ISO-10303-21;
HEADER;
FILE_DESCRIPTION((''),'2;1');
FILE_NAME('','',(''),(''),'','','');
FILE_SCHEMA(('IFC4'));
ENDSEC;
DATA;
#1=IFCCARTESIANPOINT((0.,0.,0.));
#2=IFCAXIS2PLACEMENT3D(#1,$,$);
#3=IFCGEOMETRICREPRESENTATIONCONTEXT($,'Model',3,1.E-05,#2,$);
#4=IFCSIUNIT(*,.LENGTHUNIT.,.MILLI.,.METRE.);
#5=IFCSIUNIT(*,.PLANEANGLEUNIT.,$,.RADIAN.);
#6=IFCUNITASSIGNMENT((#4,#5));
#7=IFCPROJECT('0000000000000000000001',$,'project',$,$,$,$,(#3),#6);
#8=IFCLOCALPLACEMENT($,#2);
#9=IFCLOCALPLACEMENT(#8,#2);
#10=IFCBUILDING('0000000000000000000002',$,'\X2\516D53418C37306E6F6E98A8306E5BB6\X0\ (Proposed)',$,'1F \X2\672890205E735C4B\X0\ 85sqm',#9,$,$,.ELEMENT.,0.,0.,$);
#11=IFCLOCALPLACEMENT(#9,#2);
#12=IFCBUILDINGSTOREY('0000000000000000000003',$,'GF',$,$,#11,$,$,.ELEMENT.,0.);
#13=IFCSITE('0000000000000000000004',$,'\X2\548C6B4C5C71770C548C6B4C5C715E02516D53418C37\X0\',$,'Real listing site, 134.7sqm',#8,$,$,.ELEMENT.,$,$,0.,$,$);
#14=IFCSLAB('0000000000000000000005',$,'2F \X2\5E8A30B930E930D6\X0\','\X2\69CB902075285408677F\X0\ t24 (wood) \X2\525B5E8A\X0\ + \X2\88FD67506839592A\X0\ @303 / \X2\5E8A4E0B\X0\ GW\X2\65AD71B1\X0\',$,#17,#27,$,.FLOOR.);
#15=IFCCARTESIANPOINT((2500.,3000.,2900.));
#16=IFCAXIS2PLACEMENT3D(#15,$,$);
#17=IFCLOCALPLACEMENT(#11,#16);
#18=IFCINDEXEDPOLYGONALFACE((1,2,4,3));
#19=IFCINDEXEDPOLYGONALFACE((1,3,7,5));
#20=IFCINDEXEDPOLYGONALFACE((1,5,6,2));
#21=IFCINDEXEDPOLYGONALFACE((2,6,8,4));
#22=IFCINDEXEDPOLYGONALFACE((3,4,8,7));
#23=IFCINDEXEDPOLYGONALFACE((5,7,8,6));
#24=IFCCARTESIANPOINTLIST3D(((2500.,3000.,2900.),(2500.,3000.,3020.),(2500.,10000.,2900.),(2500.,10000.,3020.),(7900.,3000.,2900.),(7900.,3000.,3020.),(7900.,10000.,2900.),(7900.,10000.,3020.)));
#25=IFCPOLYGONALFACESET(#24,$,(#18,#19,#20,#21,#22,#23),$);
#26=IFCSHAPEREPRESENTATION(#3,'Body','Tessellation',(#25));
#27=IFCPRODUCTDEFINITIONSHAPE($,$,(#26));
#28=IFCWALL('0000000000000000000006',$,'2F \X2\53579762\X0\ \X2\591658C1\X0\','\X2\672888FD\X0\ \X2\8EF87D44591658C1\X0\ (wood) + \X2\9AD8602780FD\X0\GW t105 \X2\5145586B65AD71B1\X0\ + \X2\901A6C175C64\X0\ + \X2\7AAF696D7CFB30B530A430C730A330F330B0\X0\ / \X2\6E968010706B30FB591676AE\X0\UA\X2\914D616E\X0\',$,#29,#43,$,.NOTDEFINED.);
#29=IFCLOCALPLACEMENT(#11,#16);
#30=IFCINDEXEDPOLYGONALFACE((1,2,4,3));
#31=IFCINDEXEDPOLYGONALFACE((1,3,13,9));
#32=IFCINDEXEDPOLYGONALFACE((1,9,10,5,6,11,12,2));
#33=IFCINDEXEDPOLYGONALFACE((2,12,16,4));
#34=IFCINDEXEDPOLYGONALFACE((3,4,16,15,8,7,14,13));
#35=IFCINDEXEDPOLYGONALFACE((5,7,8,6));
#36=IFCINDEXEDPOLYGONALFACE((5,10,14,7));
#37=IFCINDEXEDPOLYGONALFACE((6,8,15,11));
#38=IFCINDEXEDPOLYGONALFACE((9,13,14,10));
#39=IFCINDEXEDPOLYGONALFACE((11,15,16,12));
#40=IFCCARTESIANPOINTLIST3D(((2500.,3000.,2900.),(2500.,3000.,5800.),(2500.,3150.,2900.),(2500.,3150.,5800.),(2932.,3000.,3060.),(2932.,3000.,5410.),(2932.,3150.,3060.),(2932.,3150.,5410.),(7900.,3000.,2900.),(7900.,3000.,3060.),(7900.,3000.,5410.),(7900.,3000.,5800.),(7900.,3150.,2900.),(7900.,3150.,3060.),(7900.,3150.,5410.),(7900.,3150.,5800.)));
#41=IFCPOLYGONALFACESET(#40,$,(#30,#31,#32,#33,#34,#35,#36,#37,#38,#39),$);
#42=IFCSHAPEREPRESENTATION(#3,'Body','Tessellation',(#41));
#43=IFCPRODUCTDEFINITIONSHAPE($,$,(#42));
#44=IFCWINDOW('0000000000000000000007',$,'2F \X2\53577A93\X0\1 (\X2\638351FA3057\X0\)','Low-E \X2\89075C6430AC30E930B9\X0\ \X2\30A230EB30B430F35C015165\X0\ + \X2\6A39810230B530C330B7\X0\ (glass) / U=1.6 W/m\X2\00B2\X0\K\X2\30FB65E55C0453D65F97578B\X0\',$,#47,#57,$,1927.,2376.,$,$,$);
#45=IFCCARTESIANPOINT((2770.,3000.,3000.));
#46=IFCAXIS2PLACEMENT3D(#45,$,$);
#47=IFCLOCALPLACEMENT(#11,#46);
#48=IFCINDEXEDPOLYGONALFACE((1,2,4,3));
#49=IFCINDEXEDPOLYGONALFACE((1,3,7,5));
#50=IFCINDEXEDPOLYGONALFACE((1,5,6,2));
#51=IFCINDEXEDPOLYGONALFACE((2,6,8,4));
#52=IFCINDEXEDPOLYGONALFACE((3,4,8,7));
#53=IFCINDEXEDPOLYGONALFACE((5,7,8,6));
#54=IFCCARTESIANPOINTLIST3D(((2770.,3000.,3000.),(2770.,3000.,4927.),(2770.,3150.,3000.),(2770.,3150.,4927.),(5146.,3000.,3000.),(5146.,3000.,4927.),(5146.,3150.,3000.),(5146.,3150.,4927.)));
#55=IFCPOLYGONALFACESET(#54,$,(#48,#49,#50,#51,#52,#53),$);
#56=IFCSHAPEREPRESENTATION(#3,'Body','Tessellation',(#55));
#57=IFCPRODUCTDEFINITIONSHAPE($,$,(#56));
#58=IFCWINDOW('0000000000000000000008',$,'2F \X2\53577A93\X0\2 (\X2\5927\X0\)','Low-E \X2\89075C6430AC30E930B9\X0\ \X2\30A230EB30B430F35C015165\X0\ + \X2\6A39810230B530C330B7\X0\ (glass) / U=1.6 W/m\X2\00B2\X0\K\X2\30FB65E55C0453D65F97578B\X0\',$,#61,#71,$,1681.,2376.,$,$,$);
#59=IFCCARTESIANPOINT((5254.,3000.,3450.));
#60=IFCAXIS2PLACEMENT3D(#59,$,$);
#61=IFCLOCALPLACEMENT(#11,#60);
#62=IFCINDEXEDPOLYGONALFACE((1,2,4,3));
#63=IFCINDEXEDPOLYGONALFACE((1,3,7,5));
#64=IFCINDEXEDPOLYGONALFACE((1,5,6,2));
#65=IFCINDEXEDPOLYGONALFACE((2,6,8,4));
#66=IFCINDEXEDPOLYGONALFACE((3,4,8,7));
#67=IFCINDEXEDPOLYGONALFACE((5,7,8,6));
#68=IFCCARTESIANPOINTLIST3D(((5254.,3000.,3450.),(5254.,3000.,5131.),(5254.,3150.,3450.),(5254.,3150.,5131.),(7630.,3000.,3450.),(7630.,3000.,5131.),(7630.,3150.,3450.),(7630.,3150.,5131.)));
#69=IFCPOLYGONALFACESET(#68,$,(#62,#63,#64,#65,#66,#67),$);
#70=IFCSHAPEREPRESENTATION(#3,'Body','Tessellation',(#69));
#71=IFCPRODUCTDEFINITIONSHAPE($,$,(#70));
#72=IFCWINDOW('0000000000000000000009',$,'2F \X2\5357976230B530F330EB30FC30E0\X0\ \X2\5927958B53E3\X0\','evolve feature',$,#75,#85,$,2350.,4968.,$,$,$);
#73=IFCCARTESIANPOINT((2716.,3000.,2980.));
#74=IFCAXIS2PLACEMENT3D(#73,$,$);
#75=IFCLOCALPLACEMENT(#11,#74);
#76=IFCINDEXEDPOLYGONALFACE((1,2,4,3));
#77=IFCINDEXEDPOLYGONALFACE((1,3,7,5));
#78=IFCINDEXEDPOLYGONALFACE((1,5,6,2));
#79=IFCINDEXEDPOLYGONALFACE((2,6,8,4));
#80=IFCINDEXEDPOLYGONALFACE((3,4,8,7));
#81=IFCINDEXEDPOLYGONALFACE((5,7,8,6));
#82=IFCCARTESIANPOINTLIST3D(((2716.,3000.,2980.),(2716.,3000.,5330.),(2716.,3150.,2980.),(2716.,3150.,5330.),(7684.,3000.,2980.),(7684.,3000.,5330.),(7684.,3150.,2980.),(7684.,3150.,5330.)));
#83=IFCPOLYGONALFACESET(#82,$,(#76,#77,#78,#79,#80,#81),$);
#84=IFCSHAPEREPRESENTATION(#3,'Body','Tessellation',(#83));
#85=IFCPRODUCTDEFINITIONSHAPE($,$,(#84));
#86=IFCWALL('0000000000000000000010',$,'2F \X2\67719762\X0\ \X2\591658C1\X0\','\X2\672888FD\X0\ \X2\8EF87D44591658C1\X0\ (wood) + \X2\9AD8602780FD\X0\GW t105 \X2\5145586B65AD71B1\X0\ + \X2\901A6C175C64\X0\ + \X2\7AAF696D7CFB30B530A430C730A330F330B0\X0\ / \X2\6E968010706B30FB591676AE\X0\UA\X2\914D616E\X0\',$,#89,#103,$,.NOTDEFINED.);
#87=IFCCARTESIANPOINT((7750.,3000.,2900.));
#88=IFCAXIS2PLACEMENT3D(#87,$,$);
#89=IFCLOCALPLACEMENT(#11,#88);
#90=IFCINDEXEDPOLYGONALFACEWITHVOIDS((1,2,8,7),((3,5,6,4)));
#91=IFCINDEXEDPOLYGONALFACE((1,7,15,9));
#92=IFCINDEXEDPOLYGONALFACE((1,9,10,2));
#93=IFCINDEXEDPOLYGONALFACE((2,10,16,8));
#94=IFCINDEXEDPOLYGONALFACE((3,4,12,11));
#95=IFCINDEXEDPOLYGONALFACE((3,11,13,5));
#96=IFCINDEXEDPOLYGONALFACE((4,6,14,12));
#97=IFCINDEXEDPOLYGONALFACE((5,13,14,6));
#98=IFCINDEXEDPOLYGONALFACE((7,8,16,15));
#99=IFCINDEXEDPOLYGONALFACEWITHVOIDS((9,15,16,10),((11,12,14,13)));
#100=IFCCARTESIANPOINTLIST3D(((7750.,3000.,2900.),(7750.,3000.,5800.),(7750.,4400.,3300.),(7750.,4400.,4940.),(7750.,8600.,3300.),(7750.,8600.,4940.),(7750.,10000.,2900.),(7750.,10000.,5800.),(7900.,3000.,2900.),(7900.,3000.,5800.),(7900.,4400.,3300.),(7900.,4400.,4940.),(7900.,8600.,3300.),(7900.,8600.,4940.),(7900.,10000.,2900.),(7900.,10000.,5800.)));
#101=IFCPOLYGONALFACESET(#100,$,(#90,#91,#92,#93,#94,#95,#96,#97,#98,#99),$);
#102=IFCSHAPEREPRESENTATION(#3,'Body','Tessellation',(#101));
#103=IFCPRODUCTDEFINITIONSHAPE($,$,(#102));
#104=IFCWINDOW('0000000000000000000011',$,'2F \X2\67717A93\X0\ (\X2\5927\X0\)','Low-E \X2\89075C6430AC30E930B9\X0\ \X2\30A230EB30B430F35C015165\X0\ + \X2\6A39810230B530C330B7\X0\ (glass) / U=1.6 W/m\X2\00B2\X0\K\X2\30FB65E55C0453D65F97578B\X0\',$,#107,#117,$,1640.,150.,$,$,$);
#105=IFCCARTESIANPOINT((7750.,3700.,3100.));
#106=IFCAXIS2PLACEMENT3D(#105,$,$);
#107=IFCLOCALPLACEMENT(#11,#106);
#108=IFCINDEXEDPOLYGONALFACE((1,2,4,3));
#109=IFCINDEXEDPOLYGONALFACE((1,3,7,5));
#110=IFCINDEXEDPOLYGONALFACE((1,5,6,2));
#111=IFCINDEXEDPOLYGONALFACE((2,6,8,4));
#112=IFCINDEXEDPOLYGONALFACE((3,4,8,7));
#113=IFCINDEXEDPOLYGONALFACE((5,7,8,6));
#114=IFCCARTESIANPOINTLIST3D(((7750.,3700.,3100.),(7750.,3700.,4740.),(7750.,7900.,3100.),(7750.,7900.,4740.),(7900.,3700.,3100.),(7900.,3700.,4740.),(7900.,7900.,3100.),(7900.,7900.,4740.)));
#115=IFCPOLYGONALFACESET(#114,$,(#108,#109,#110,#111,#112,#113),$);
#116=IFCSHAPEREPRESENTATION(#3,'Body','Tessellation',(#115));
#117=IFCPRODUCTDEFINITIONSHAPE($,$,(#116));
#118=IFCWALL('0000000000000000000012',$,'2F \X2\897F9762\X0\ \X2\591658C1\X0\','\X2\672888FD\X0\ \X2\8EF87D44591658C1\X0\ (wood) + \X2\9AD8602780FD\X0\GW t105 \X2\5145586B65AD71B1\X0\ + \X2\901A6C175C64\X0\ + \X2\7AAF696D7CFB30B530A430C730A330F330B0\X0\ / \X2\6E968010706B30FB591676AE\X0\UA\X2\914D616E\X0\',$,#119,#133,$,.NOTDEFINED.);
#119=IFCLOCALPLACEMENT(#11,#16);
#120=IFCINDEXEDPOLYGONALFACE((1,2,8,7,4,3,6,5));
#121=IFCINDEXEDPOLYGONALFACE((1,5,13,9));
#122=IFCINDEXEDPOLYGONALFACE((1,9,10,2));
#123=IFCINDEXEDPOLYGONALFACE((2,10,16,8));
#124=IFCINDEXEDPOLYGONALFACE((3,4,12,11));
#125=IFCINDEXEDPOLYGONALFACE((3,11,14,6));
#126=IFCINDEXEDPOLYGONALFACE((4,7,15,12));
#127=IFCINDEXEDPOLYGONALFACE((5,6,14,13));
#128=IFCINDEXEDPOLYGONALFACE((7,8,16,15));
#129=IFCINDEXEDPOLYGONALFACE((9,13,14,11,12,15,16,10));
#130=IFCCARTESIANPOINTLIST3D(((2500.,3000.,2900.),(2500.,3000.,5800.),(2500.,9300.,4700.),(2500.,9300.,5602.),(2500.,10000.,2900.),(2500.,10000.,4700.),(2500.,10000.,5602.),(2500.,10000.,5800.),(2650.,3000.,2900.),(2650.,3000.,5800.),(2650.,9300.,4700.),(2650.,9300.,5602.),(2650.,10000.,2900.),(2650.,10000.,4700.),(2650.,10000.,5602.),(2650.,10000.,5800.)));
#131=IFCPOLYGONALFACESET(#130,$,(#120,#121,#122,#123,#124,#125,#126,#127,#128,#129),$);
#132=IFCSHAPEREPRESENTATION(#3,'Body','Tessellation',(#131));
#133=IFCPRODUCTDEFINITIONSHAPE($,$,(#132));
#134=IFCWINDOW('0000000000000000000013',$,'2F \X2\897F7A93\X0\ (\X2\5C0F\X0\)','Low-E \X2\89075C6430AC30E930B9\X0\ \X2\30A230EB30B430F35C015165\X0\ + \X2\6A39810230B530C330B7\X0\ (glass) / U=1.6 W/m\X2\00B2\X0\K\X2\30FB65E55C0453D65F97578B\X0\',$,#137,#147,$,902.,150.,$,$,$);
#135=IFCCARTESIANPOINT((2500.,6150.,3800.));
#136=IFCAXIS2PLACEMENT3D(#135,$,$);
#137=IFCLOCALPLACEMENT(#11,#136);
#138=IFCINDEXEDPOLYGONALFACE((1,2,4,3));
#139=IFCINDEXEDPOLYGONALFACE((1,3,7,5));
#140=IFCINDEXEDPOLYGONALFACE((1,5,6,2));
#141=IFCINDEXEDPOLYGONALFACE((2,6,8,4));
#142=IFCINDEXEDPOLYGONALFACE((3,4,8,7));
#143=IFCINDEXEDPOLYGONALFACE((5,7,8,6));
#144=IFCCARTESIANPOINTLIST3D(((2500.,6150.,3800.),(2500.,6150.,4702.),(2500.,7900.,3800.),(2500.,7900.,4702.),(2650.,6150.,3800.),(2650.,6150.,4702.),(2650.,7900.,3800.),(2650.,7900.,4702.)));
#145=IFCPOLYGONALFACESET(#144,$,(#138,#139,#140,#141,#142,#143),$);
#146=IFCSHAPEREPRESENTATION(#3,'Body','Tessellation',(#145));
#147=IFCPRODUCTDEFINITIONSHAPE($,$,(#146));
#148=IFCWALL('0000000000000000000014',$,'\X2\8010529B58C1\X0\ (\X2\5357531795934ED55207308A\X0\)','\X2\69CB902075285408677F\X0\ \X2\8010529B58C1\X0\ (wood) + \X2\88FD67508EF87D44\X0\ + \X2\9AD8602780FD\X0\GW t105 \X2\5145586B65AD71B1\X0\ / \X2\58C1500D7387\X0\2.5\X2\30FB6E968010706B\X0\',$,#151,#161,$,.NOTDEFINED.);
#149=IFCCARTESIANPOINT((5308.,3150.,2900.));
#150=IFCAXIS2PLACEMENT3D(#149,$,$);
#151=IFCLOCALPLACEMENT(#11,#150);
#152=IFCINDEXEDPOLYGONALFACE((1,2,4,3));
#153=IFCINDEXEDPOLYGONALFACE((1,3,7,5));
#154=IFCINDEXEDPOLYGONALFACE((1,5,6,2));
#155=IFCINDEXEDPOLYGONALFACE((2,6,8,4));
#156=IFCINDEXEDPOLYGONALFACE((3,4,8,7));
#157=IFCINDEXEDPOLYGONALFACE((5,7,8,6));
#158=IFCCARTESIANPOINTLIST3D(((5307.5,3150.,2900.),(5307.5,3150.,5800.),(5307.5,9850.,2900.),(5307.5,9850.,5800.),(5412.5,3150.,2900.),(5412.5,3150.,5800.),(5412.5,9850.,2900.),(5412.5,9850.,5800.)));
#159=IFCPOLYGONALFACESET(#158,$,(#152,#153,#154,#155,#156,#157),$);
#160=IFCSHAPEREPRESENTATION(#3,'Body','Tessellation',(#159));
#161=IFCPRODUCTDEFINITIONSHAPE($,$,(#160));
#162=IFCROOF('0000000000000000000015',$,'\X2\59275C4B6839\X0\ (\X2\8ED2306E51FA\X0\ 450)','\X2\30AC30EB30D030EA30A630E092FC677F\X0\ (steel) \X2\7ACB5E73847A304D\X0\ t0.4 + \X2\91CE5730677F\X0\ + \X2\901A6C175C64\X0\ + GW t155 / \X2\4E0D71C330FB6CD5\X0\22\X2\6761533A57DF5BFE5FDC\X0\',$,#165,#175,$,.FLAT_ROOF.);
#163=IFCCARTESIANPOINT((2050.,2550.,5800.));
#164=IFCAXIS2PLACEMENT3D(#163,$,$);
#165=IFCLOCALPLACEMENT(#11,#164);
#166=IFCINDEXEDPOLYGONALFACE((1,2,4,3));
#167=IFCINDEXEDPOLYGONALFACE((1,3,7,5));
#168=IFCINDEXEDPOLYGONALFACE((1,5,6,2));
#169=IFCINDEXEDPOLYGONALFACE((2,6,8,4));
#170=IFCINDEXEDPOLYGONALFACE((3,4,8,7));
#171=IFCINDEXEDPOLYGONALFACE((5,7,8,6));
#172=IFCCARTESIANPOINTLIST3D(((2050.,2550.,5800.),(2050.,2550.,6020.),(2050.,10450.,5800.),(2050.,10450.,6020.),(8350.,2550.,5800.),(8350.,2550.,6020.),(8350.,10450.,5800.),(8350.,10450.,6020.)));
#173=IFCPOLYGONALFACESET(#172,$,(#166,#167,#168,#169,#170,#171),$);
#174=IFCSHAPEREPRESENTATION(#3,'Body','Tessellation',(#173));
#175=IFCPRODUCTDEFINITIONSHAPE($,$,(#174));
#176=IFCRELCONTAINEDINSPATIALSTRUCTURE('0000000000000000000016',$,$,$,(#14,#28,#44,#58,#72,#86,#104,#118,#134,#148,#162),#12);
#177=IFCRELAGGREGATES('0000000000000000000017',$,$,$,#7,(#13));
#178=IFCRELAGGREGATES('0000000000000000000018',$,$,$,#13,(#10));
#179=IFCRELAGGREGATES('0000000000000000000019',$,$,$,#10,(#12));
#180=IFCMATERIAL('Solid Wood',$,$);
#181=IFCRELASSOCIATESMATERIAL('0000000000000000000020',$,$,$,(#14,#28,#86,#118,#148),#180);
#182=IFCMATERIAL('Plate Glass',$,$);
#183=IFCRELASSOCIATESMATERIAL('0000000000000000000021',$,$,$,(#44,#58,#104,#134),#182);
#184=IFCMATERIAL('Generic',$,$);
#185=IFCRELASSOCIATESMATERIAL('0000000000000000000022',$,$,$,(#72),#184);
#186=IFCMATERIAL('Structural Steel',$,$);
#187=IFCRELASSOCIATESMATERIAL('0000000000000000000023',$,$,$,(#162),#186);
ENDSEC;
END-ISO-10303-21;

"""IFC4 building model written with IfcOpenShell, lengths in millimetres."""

from ifc_helpers import new_model, si_unit, frame, frame_2d, origin, place, context, project, spatial, rectangle, extrude, material, element, fill, save


model = new_model("IFC4")

# Units and contexts
model_context = context("Model", 3, precision=1e-05, world=origin())
ifc_project = project(units=[si_unit("LENGTHUNIT", "METRE", prefix="MILLI"), si_unit("PLANEANGLEUNIT", "RADIAN")], contexts=[model_context])

# Site, building, storey
site_placement = place(None, origin())
site = spatial("IfcSite", under=ifc_project, at=site_placement, Name="和歌山県和歌山市六十谷", ObjectType="Real listing site, 134.7sqm", CompositionType="ELEMENT", RefElevation=0.0)
building_placement = place(site_placement, origin())
building = spatial("IfcBuilding", under=site, at=building_placement, Name="六十谷の潮風の家 (Proposed)", ObjectType="1F 木造平屋 85sqm", CompositionType="ELEMENT", ElevationOfRefHeight=0.0, ElevationOfTerrain=0.0)
storey_placement = place(building_placement, origin())
storey = spatial("IfcBuildingStorey", under=building, at=storey_placement, Name="GF", CompositionType="ELEMENT", Elevation=0.0)

# Slab
ifc_material_1 = material(Name="Solid Wood")
slab_placement = place(storey_placement, frame((2500.0, 3000.0, 2900.0)))
element("IfcSlab", 1, at=slab_placement, inside=storey, material=ifc_material_1, Name="2F 床スラブ", Description="構造用合板 t24 (wood) 剛床 + 製材根太 @303 / 床下 GW断熱", PredefinedType="FLOOR", context=model_context, shape_type="SweptSolid", body=[
    extrude(rectangle(XDim=5400.0, YDim=7000.0, at=frame_2d((2700.0, 3500.0))), frame((2500.0, 3000.0, 2900.0)), (0.0, 0.0, 1.0), 120.0),
])

# Wall, openings, windows
wall_1_placement = place(storey_placement, frame((2500.0, 3000.0, 2900.0)))
wall_1 = element("IfcWall", 2, at=wall_1_placement, inside=storey, material=ifc_material_1, Name="2F 南面 外壁", Description="木製 軸組外壁 (wood) + 高性能GW t105 充填断熱 + 通気層 + 窯業系サイディング / 準耐火・外皮UA配慮", PredefinedType="NOTDEFINED", context=model_context, shape_type="SweptSolid", body=[
    extrude(rectangle(XDim=5400.0, YDim=150.0, at=frame_2d((2700.0, 75.0))), frame((2500.0, 3000.0, 2900.0)), (0.0, 0.0, 1.0), 2900.0),
])
opening_1_placement = place(storey_placement, frame((2770.0, 3000.0, 3000.0)))
opening_1 = element("IfcOpeningElement", 3, at=opening_1_placement, cuts=wall_1, PredefinedType="NOTDEFINED", context=model_context, shape_type="SweptSolid", body=[
    extrude(rectangle(XDim=2376.0, YDim=150.0, at=frame_2d((1188.0, 75.0))), frame((2770.0, 3000.0, 3000.0)), (0.0, 0.0, 1.0), 1927.0),
])
opening_2_placement = place(storey_placement, frame((5254.0, 3000.0, 3450.0)))
opening_2 = element("IfcOpeningElement", 4, at=opening_2_placement, cuts=wall_1, PredefinedType="NOTDEFINED", context=model_context, shape_type="SweptSolid", body=[
    extrude(rectangle(XDim=2376.0, YDim=150.0, at=frame_2d((1188.0, 75.0))), frame((5254.0, 3000.0, 3450.0)), (0.0, 0.0, 1.0), 1681.0),
])
opening_3_placement = place(storey_placement, frame((2716.0, 3000.0, 2980.0)))
opening_3 = element("IfcOpeningElement", 5, at=opening_3_placement, cuts=wall_1, PredefinedType="NOTDEFINED", context=model_context, shape_type="SweptSolid", body=[
    extrude(rectangle(XDim=4968.0, YDim=150.0, at=frame_2d((2484.0, 75.0))), frame((2716.0, 3000.0, 2980.0)), (0.0, 0.0, 1.0), 2350.0),
])
ifc_material_2 = material(Name="Plate Glass")
window_1_placement = place(storey_placement, frame((2770.0, 3000.0, 3000.0)))
window_1 = element("IfcWindow", 6, at=window_1_placement, inside=storey, material=ifc_material_2, Name="2F 南窓1 (掃出し)", Description="Low-E 複層ガラス アルゴン封入 + 樹脂サッシ (glass) / U=1.6 W/m²K・日射取得型", OverallHeight=1927.0, OverallWidth=2376.0, context=model_context, shape_type="SweptSolid", body=[
    extrude(rectangle(XDim=2376.0, YDim=150.0, at=frame_2d((1188.0, 75.0))), frame((2770.0, 3000.0, 3000.0)), (0.0, 0.0, 1.0), 1927.0),
])
fill(opening_1, window_1)
window_2_placement = place(storey_placement, frame((5254.0, 3000.0, 3450.0)))
window_2 = element("IfcWindow", 7, at=window_2_placement, inside=storey, material=ifc_material_2, Name="2F 南窓2 (大)", Description="Low-E 複層ガラス アルゴン封入 + 樹脂サッシ (glass) / U=1.6 W/m²K・日射取得型", OverallHeight=1681.0, OverallWidth=2376.0, context=model_context, shape_type="SweptSolid", body=[
    extrude(rectangle(XDim=2376.0, YDim=150.0, at=frame_2d((1188.0, 75.0))), frame((5254.0, 3000.0, 3450.0)), (0.0, 0.0, 1.0), 1681.0),
])
fill(opening_2, window_2)
ifc_material_3 = material(Name="Generic")
window_3_placement = place(storey_placement, frame((2716.0, 3000.0, 2980.0)))
window_3 = element("IfcWindow", 8, at=window_3_placement, inside=storey, material=ifc_material_3, Name="2F 南面サンルーム 大開口", Description="evolve feature", OverallHeight=2350.0, OverallWidth=4968.0, context=model_context, shape_type="SweptSolid", body=[
    extrude(rectangle(XDim=4968.0, YDim=150.0, at=frame_2d((2484.0, 75.0))), frame((2716.0, 3000.0, 2980.0)), (0.0, 0.0, 1.0), 2350.0),
])
fill(opening_3, window_3)

# Walls, openings, windows
wall_2_placement = place(storey_placement, frame((7750.0, 3000.0, 2900.0)))
wall_2 = element("IfcWall", 9, at=wall_2_placement, inside=storey, material=ifc_material_1, Name="2F 東面 外壁", Description="木製 軸組外壁 (wood) + 高性能GW t105 充填断熱 + 通気層 + 窯業系サイディング / 準耐火・外皮UA配慮", PredefinedType="NOTDEFINED", context=model_context, shape_type="SweptSolid", body=[
    extrude(rectangle(XDim=150.0, YDim=7000.0, at=frame_2d((75.0, 3500.0))), frame((7750.0, 3000.0, 2900.0)), (0.0, 0.0, 1.0), 2900.0),
])
opening_4_placement = place(storey_placement, frame((7750.0, 3700.0, 3100.0)))
opening_4 = element("IfcOpeningElement", 10, at=opening_4_placement, cuts=wall_2, PredefinedType="NOTDEFINED", context=model_context, shape_type="SweptSolid", body=[
    extrude(rectangle(XDim=150.0, YDim=4200.0, at=frame_2d((75.0, 2100.0))), frame((7750.0, 3700.0, 3100.0)), (0.0, 0.0, 1.0), 1640.0),
])
window_4_placement = place(storey_placement, frame((7750.0, 3700.0, 3100.0)))
window_4 = element("IfcWindow", 11, at=window_4_placement, inside=storey, material=ifc_material_2, Name="2F 東窓 (大)", Description="Low-E 複層ガラス アルゴン封入 + 樹脂サッシ (glass) / U=1.6 W/m²K・日射取得型", OverallHeight=1640.0, OverallWidth=150.0, context=model_context, shape_type="SweptSolid", body=[
    extrude(rectangle(XDim=150.0, YDim=4200.0, at=frame_2d((75.0, 2100.0))), frame((7750.0, 3700.0, 3100.0)), (0.0, 0.0, 1.0), 1640.0),
])
fill(opening_4, window_4)
wall_3_placement = place(storey_placement, frame((2500.0, 3000.0, 2900.0)))
wall_3 = element("IfcWall", 12, at=wall_3_placement, inside=storey, material=ifc_material_1, Name="2F 西面 外壁", Description="木製 軸組外壁 (wood) + 高性能GW t105 充填断熱 + 通気層 + 窯業系サイディング / 準耐火・外皮UA配慮", PredefinedType="NOTDEFINED", context=model_context, shape_type="SweptSolid", body=[
    extrude(rectangle(XDim=150.0, YDim=7000.0, at=frame_2d((75.0, 3500.0))), frame((2500.0, 3000.0, 2900.0)), (0.0, 0.0, 1.0), 2900.0),
])
opening_5_placement = place(storey_placement, frame((2500.0, 6150.0, 3800.0)))
opening_5 = element("IfcOpeningElement", 13, at=opening_5_placement, cuts=wall_3, PredefinedType="NOTDEFINED", context=model_context, shape_type="SweptSolid", body=[
    extrude(rectangle(XDim=150.0, YDim=1750.0, at=frame_2d((75.0, 875.0))), frame((2500.0, 6150.0, 3800.0)), (0.0, 0.0, 1.0), 902.0),
])
window_5_placement = place(storey_placement, frame((2500.0, 6150.0, 3800.0)))
window_5 = element("IfcWindow", 14, at=window_5_placement, inside=storey, material=ifc_material_2, Name="2F 西窓 (小)", Description="Low-E 複層ガラス アルゴン封入 + 樹脂サッシ (glass) / U=1.6 W/m²K・日射取得型", OverallHeight=902.0, OverallWidth=150.0, context=model_context, shape_type="SweptSolid", body=[
    extrude(rectangle(XDim=150.0, YDim=1750.0, at=frame_2d((75.0, 875.0))), frame((2500.0, 6150.0, 3800.0)), (0.0, 0.0, 1.0), 902.0),
])
fill(opening_5, window_5)

# Wall
wall_4_placement = place(storey_placement, frame((5308.0, 3150.0, 2900.0)))
element("IfcWall", 15, at=wall_4_placement, inside=storey, material=ifc_material_1, Name="耐力壁 (南北間仕切り)", Description="構造用合板 耐力壁 (wood) + 製材軸組 + 高性能GW t105 充填断熱 / 壁倍率2.5・準耐火", PredefinedType="NOTDEFINED", context=model_context, shape_type="SweptSolid", body=[
    extrude(rectangle(XDim=105.0, YDim=6700.0, at=frame_2d((52.0, 3350.0))), frame((5308.0, 3150.0, 2900.0)), (0.0, 0.0, 1.0), 2900.0),
])

# Roof
ifc_material_4 = material(Name="Structural Steel")
roof_1_placement = place(storey_placement, frame((2050.0, 2550.0, 5800.0)))
element("IfcRoof", 16, at=roof_1_placement, inside=storey, material=ifc_material_4, Name="大屋根 (軒の出 450)", Description="ガルバリウム鋼板 (steel) 立平葺き t0.4 + 野地板 + 通気層 + GW t155 / 不燃・法22条区域対応", PredefinedType="FLAT_ROOF", context=model_context, shape_type="SweptSolid", body=[
    extrude(rectangle(XDim=6300.0, YDim=7900.0, at=frame_2d((3150.0, 3950.0))), frame((2050.0, 2550.0, 5800.0)), (0.0, 0.0, 1.0), 220.0),
])

save(model, "model.ifc")
